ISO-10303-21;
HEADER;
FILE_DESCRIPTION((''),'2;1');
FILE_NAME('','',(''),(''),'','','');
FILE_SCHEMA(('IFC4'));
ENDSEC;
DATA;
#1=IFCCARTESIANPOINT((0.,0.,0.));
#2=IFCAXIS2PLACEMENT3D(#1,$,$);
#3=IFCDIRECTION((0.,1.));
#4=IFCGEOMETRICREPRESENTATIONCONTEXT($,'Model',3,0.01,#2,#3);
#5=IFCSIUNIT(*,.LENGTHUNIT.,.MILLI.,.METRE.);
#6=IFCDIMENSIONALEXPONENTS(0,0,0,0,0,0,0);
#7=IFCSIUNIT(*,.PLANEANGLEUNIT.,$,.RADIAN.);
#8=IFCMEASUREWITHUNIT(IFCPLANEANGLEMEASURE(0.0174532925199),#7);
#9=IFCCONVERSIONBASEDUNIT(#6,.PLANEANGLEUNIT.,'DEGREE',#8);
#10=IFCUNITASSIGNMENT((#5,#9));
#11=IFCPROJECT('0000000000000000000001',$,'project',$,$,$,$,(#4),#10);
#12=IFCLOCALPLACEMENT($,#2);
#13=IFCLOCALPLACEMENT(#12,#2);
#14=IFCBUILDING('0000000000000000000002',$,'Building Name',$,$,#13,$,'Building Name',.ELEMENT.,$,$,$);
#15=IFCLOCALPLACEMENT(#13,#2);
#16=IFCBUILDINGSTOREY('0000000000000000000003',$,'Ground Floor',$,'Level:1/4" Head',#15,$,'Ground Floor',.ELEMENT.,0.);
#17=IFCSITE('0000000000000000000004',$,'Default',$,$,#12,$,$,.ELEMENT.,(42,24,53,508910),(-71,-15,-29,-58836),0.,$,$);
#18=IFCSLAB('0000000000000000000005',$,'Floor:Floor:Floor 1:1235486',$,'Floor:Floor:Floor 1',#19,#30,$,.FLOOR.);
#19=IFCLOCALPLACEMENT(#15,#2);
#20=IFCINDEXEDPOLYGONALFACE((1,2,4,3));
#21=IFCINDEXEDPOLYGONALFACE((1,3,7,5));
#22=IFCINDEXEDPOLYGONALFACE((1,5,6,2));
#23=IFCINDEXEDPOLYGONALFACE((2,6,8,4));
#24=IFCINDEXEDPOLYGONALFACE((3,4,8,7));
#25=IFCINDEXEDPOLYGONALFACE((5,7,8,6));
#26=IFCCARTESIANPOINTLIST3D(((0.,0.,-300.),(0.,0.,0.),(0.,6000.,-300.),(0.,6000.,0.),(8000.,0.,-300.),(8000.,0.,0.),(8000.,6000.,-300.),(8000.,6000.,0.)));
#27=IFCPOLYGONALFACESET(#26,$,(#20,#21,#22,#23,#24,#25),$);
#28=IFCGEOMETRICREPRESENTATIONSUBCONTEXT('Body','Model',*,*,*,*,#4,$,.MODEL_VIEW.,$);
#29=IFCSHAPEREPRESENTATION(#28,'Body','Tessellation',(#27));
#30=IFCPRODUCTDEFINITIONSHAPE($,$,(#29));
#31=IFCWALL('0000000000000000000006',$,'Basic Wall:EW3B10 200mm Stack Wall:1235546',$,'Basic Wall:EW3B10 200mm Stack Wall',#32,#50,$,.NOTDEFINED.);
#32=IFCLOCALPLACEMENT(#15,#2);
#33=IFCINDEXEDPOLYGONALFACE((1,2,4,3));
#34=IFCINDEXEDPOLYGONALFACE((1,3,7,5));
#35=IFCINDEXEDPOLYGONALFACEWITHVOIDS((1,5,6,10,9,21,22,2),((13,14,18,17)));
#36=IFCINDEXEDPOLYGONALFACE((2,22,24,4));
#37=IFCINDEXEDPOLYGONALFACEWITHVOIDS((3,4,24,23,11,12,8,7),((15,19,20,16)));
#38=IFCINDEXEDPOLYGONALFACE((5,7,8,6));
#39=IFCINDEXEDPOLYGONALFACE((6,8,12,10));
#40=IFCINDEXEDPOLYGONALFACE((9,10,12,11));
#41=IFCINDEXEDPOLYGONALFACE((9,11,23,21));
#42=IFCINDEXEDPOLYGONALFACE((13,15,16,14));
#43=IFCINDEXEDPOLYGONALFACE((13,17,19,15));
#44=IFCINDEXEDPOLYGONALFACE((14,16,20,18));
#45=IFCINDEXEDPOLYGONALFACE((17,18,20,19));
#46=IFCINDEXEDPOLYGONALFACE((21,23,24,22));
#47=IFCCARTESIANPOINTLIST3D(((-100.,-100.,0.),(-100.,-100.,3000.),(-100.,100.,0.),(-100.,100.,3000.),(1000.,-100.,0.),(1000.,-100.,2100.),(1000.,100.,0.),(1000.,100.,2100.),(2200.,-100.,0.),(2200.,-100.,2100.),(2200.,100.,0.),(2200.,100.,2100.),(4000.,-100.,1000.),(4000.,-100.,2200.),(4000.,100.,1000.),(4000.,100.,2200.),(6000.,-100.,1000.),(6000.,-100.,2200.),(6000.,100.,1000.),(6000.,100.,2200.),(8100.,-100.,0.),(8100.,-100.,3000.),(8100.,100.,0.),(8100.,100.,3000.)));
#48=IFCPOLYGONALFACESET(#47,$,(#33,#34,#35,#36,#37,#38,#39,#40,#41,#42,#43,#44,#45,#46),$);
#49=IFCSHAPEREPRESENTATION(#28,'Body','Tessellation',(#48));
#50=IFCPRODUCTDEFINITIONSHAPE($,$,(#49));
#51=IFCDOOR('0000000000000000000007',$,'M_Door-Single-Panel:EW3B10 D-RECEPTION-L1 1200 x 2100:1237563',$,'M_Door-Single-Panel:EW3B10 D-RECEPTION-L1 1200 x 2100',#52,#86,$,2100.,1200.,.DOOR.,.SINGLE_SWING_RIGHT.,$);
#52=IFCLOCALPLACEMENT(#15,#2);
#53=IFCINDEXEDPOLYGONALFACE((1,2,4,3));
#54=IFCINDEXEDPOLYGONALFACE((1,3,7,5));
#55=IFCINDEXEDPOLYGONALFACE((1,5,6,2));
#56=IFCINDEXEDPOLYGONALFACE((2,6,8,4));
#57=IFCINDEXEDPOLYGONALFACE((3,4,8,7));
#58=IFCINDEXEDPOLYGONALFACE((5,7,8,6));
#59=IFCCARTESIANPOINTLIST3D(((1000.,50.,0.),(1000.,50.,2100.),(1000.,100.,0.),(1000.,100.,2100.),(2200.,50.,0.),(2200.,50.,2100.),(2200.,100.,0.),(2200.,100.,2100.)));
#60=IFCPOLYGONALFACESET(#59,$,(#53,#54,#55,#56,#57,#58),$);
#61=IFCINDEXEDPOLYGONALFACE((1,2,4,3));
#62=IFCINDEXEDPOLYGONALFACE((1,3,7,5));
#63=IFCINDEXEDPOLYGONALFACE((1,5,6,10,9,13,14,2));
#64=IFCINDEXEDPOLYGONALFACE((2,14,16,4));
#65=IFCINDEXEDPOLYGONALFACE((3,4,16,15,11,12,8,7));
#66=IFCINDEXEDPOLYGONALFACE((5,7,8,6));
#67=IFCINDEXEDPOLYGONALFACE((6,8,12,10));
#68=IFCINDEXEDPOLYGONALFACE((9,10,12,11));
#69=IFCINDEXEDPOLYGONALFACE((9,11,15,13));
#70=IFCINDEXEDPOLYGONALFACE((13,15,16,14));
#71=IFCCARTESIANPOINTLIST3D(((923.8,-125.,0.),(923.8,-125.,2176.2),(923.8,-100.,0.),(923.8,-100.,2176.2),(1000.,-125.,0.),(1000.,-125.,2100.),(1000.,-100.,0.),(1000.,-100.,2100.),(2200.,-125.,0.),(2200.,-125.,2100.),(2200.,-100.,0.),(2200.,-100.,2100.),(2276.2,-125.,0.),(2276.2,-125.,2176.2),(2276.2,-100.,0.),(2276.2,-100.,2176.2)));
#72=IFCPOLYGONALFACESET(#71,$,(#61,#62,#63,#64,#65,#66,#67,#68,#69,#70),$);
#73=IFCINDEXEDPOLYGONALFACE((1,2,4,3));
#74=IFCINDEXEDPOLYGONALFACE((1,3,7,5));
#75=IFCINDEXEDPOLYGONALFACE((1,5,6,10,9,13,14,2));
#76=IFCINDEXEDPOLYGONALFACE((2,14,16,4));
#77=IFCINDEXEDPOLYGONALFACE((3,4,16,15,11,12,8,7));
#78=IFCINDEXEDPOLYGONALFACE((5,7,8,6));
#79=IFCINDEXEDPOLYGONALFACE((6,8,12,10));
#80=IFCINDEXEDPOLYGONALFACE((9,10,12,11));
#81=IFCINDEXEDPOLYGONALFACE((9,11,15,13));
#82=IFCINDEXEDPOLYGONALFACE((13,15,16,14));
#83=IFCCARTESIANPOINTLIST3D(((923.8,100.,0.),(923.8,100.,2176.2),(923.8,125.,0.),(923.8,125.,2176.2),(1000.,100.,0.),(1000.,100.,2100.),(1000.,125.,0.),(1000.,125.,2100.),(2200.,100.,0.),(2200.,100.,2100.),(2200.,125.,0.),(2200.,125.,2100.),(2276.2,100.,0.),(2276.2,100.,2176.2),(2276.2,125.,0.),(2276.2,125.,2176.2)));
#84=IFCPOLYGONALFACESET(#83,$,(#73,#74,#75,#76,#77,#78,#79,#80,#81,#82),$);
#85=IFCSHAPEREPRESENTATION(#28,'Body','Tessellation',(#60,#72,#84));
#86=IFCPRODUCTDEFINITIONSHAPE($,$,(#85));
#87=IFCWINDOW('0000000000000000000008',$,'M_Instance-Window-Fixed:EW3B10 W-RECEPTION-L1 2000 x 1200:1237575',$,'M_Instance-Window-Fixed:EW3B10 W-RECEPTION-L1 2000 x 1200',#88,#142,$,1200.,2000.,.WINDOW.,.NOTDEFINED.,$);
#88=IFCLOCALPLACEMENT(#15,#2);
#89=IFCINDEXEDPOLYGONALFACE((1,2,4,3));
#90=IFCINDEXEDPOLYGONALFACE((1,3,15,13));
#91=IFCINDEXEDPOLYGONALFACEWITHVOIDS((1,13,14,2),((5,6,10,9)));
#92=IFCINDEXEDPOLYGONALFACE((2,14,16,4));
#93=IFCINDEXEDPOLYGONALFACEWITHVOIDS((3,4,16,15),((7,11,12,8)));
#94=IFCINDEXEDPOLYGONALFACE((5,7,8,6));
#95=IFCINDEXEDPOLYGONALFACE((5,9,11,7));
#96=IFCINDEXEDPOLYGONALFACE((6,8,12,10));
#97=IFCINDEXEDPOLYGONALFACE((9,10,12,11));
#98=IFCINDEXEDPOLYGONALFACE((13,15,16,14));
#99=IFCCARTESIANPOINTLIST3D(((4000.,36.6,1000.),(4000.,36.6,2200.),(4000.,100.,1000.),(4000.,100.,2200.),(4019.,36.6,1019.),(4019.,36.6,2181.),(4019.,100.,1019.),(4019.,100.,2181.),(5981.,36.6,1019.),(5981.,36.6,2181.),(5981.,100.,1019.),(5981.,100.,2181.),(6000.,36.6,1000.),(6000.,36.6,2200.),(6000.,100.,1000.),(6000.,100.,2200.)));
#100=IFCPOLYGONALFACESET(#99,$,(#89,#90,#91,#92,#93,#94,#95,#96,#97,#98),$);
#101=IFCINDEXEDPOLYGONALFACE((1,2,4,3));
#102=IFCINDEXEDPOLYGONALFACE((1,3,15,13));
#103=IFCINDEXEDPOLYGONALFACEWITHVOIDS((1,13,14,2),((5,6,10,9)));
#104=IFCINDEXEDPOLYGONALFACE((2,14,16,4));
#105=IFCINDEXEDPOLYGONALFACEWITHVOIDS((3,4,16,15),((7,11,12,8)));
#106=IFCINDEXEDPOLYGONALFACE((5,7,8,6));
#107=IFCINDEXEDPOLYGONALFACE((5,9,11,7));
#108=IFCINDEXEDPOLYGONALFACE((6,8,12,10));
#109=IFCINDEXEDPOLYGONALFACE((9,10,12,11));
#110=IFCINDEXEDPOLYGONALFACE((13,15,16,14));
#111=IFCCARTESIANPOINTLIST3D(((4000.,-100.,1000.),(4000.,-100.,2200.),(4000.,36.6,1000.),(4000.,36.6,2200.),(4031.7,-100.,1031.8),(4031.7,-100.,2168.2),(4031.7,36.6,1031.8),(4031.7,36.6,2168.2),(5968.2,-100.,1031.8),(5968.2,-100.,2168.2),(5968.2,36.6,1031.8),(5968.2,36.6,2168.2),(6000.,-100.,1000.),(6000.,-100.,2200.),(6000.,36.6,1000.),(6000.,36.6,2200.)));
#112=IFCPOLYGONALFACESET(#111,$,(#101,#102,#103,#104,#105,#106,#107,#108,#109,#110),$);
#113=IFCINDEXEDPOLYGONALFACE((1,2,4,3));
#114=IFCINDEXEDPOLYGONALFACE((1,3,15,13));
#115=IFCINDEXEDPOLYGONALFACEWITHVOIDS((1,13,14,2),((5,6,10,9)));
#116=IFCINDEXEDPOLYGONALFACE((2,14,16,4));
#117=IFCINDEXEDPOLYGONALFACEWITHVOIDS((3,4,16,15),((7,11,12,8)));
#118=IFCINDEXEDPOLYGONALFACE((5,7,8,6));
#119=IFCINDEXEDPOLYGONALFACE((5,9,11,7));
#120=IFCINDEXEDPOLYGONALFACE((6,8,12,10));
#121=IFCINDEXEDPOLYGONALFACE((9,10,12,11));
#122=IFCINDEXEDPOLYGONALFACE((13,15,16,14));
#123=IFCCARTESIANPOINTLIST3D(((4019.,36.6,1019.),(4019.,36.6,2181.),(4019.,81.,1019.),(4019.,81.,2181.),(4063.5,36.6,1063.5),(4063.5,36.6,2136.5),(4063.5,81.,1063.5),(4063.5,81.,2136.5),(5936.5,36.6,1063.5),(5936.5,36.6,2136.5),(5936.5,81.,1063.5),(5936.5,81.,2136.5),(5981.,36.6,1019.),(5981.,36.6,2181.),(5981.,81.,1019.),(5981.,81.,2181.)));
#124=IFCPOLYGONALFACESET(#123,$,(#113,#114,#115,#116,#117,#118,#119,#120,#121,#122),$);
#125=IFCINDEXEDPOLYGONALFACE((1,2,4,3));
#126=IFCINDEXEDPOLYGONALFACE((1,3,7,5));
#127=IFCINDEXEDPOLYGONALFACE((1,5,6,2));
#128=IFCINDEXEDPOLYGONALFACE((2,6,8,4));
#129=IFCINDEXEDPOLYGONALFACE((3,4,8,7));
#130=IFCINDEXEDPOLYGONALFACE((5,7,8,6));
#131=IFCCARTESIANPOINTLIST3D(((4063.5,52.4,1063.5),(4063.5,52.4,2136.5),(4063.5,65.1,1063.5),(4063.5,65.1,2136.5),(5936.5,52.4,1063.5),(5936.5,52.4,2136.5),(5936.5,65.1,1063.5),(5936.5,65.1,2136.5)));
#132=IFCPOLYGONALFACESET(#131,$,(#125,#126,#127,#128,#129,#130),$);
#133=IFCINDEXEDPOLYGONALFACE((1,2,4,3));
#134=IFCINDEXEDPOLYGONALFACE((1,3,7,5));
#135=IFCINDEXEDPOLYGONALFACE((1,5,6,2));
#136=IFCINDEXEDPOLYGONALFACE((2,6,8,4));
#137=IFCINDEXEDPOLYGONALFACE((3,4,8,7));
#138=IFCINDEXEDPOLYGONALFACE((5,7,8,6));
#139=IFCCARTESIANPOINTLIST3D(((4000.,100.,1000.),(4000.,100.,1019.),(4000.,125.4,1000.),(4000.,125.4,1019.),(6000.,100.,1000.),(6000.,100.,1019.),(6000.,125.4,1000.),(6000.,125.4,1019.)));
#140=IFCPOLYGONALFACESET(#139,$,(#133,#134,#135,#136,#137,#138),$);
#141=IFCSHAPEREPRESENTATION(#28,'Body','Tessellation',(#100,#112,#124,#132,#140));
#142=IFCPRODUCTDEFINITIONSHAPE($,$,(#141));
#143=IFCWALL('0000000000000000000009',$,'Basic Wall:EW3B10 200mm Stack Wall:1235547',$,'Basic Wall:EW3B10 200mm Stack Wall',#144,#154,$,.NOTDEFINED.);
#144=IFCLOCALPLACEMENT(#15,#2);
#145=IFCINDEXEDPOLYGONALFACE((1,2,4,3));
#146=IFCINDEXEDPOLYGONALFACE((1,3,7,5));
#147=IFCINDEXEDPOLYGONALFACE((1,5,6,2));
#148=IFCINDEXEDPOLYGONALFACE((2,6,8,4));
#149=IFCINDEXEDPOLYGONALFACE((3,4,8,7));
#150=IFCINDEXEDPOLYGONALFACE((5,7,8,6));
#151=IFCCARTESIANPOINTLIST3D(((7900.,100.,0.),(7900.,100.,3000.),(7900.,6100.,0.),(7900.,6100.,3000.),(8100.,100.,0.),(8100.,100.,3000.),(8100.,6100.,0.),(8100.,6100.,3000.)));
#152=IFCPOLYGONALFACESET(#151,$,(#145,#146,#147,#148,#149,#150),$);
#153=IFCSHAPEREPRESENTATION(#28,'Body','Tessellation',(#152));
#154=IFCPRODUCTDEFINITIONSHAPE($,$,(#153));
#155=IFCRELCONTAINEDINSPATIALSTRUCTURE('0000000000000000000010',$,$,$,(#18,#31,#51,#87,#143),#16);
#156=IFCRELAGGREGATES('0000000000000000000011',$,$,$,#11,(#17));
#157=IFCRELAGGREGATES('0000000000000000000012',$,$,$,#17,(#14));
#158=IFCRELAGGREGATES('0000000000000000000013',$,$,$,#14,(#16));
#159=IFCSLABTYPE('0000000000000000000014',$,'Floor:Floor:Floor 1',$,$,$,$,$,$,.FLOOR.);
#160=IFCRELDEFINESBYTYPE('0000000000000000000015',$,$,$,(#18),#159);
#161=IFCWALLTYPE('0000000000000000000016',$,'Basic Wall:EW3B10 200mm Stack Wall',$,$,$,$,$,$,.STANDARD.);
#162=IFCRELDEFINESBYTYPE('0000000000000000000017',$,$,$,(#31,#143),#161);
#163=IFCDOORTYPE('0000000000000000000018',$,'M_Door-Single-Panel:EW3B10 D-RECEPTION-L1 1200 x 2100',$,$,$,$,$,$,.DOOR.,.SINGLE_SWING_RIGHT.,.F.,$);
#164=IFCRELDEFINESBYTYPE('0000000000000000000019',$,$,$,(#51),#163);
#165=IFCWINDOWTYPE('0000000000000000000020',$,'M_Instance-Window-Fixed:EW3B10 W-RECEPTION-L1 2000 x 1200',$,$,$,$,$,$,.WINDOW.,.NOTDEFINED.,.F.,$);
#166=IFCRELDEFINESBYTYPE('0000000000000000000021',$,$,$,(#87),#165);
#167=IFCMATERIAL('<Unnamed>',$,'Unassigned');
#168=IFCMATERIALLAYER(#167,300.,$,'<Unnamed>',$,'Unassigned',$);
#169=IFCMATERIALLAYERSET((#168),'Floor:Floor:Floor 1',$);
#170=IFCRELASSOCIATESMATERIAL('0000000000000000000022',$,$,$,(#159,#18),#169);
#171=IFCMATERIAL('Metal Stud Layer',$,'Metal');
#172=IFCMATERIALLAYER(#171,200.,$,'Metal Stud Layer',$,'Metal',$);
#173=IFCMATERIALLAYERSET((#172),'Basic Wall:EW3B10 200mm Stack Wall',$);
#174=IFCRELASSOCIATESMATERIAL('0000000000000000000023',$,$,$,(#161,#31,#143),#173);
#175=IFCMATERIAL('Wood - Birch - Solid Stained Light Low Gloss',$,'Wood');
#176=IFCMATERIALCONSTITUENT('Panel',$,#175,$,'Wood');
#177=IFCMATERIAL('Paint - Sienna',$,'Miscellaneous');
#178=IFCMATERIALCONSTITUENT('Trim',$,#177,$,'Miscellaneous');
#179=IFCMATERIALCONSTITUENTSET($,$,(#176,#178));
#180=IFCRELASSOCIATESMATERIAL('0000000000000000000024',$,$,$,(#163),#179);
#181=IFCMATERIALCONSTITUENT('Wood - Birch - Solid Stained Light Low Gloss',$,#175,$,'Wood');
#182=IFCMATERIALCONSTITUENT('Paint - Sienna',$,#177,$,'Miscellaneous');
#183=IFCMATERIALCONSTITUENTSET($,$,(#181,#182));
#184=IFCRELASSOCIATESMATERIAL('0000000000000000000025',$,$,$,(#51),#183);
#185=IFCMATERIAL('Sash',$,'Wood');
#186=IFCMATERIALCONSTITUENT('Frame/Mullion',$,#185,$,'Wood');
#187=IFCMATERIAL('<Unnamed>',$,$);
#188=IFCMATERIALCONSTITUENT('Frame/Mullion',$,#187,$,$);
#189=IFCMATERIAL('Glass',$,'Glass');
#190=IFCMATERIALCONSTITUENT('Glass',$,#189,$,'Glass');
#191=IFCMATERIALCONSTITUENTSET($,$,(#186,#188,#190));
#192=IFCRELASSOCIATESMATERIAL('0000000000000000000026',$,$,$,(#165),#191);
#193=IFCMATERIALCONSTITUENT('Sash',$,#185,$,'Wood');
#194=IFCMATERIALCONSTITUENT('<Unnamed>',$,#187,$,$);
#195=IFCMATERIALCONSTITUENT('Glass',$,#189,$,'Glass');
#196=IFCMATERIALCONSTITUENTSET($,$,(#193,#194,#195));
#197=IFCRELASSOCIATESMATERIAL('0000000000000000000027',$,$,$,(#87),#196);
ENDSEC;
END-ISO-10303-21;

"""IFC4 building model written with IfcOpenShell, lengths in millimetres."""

from ifc_helpers import new_model, entity, si_unit, converted_unit, direction, frame, frame_2d, origin, origin_2d_with_axis, place, context, subcontext, project, spatial, polyline, rectangle, outline, extrude, source, transform, mapped, material, layer, layer_set, layer_usage, constituent, constituent_set, type_object, type_shapes, element, fill, save


model = new_model("IFC4")

# Units and contexts
model_context = context("Model", 3, precision=0.01, world=origin(), true_north=direction((0.0, 1.0)))
body_context = subcontext(model_context, "Body", "Model", "MODEL_VIEW")
ifc_project = project(units=[si_unit("LENGTHUNIT", "METRE", prefix="MILLI"), converted_unit("PLANEANGLEUNIT", "DEGREE", entity("IfcPlaneAngleMeasure", 0.0174532925199), si_unit("PLANEANGLEUNIT", "RADIAN"), dimensions=[0, 0, 0, 0, 0, 0, 0])], contexts=[model_context])

# Site, building, storey
site_placement = place(None, origin())
site = spatial("IfcSite", under=ifc_project, at=site_placement, Name="Default", CompositionType="ELEMENT", RefLatitude=(42, 24, 53, 508910), RefLongitude=(-71, -15, -29, -58836), RefElevation=0.0)
building_placement = place(site_placement, origin())
building = spatial("IfcBuilding", under=site, at=building_placement, Name="Building Name", LongName="Building Name", CompositionType="ELEMENT")
storey_placement = place(building_placement, origin())
storey = spatial("IfcBuildingStorey", under=building, at=storey_placement, Name="Ground Floor", ObjectType="Level:1/4\" Head", LongName="Ground Floor", CompositionType="ELEMENT", Elevation=0.0)

# Slab
ifc_material_1 = material(Name="<Unnamed>", Category="Unassigned")
ifc_layer_1 = layer(ifc_material_1, 300.0, Name="<Unnamed>", Category="Unassigned")
ifc_layer_set_1 = layer_set([ifc_layer_1], Name="Floor:Floor:Floor 1")
ifc_layer_usage_1 = layer_usage(ifc_layer_set_1, "AXIS3", "POSITIVE", 0.0)
slab_type = type_object("IfcSlabType", Name="Floor:Floor:Floor 1", PredefinedType="FLOOR", material=ifc_layer_set_1)
slab_placement = place(storey_placement, origin())
element("IfcSlab", 1, at=slab_placement, inside=storey, type_object=slab_type, material=ifc_layer_usage_1, Name="Floor:Floor:Floor 1:1235486", ObjectType="Floor:Floor:Floor 1", PredefinedType="FLOOR", context=body_context, shape_type="SweptSolid", body=[
    extrude(rectangle(XDim=6000.0, YDim=8000.0, at=origin_2d_with_axis()), frame((4000.0, 3000.0, 0.0), z_axis=(0.0, 0.0, -1.0), x_axis=(0.0, 1.0, 0.0)), (0.0, 0.0, 1.0), 300.0),
])

# Wall, openings, door, window
ifc_material_2 = material(Name="Metal Stud Layer", Category="Metal")
ifc_layer_2 = layer(ifc_material_2, 200.0, Name="Metal Stud Layer", Category="Metal")
ifc_layer_set_2 = layer_set([ifc_layer_2], Name="Basic Wall:EW3B10 200mm Stack Wall")
ifc_layer_usage_2 = layer_usage(ifc_layer_set_2, "AXIS2", "NEGATIVE", 100.0)
wall_type = type_object("IfcWallType", Name="Basic Wall:EW3B10 200mm Stack Wall", PredefinedType="STANDARD", material=ifc_layer_set_2)
wall_1_placement = place(storey_placement, frame((-100.0, 0.0, 0.0)))
wall_1 = element("IfcWall", 2, at=wall_1_placement, inside=storey, type_object=wall_type, material=ifc_layer_usage_2, Name="Basic Wall:EW3B10 200mm Stack Wall:1235546", ObjectType="Basic Wall:EW3B10 200mm Stack Wall", PredefinedType="NOTDEFINED", context=body_context, shape_type="SweptSolid", body=[
    extrude(rectangle(XDim=8200.0, YDim=200.0, at=frame_2d((4100.0, 0.0), x_axis=(1.0, 0.0))), origin(), (0.0, 0.0, 1.0), 3000.0),
])
opening_1_placement = place(wall_1_placement, frame((1100.0, -100.0, 0.0)))
opening_1 = element("IfcOpeningElement", 3, at=opening_1_placement, cuts=wall_1, PredefinedType="OPENING", context=body_context, shape_type="SweptSolid", body=[
    extrude(rectangle(XDim=1200.0, YDim=2100.0, at=frame_2d((1050.0, 600.0), x_axis=(0.0, 1.0))), frame((0.0, 0.0, 0.0), z_axis=(0.0, 1.0, 0.0), x_axis=(0.0, 0.0, 1.0)), (0.0, 0.0, 1.0), 200.0),
])
opening_2_placement = place(wall_1_placement, frame((4100.0, -100.0, 1000.0)))
opening_2 = element("IfcOpeningElement", 4, at=opening_2_placement, cuts=wall_1, PredefinedType="OPENING", context=body_context, shape_type="SweptSolid", body=[
    extrude(rectangle(XDim=1200.0, YDim=2000.0, at=frame_2d((600.0, 1000.0), x_axis=(-1.0, 0.0))), frame((0.0, 0.0, 0.0), z_axis=(0.0, 1.0, 0.0), x_axis=(0.0, 0.0, 1.0)), (0.0, 0.0, 1.0), 200.0),
])
ifc_material_3 = material(Name="Wood - Birch - Solid Stained Light Low Gloss", Category="Wood")
ifc_constituent_1 = constituent(ifc_material_3, Name="Wood - Birch - Solid Stained Light Low Gloss", Category="Wood")
ifc_material_4 = material(Name="Paint - Sienna", Category="Miscellaneous")
ifc_constituent_2 = constituent(ifc_material_4, Name="Paint - Sienna", Category="Miscellaneous")
ifc_constituent_set_1 = constituent_set(constituents=[ifc_constituent_1, ifc_constituent_2])
ifc_constituent_3 = constituent(ifc_material_3, Name="Panel", Category="Wood")
ifc_constituent_4 = constituent(ifc_material_4, Name="Trim", Category="Miscellaneous")
ifc_constituent_set_2 = constituent_set(constituents=[ifc_constituent_3, ifc_constituent_4])
door_type = type_object("IfcDoorType", Name="M_Door-Single-Panel:EW3B10 D-RECEPTION-L1 1200 x 2100", OperationType="SINGLE_SWING_RIGHT", ParameterTakesPrecedence=False, PredefinedType="DOOR", material=ifc_constituent_set_2)
shared_shape_1 = source(origin(), body_context, "Body", "SweptSolid", [
    extrude(rectangle(XDim=50.0, YDim=1200.0, at=frame_2d((0.0, 0.0), x_axis=(1.0, 0.0))), frame((600.0, 175.0, 0.0), z_axis=(0.0, 0.0, 1.0), x_axis=(0.0, 1.0, 0.0)), (0.0, 0.0, 1.0), 2100.0),
    extrude(outline(polyline([(-1107.2, -676.2), (1069.0, -676.2), (1069.0, -600.0), (-1031.0, -600.0), (-1031.0, 600.0), (1069.0, 600.0), (1069.0, 676.2), (-1107.2, 676.2), (-1107.2, -676.2)])), frame((600.0, -25.0, 1069.0), z_axis=(0.0, 1.0, 0.0), x_axis=(0.0, 0.0, -1.0)), (0.0, 0.0, 1.0), 25.0),
    extrude(outline(polyline([(-676.2, -1107.2), (676.2, -1107.2), (676.2, 1069.0), (600.0, 1069.0), (600.0, -1031.0), (-600.0, -1031.0), (-600.0, 1069.0), (-676.2, 1069.0), (-676.2, -1107.2)])), frame((600.0, 200.0, 1069.0), z_axis=(0.0, 1.0, 0.0), x_axis=(1.0, 0.0, 0.0)), (0.0, 0.0, 1.0), 25.0),
])
type_shapes(door_type, [shared_shape_1])
door_placement = place(opening_1_placement, origin())
door = element("IfcDoor", 5, at=door_placement, inside=storey, type_object=door_type, material=ifc_constituent_set_1, Name="M_Door-Single-Panel:EW3B10 D-RECEPTION-L1 1200 x 2100:1237563", ObjectType="M_Door-Single-Panel:EW3B10 D-RECEPTION-L1 1200 x 2100", OperationType="SINGLE_SWING_RIGHT", OverallHeight=2100.0, OverallWidth=1200.0, PredefinedType="DOOR", context=body_context, shape_type="MappedRepresentation", body=[
    mapped(shared_shape_1, transform((0.0, 0.0, 0.0), scale=1.0)),
])
fill(opening_1, door)
ifc_material_5 = material(Name="Sash", Category="Wood")
ifc_constituent_5 = constituent(ifc_material_5, Name="Sash", Category="Wood")
ifc_material_6 = material(Name="<Unnamed>")
ifc_constituent_6 = constituent(ifc_material_6, Name="<Unnamed>")
ifc_material_7 = material(Name="Glass", Category="Glass")
ifc_constituent_7 = constituent(ifc_material_7, Name="Glass", Category="Glass")
ifc_constituent_set_3 = constituent_set(constituents=[ifc_constituent_5, ifc_constituent_6, ifc_constituent_7])
ifc_constituent_8 = constituent(ifc_material_5, Name="Frame/Mullion", Category="Wood")
ifc_constituent_9 = constituent(ifc_material_6, Name="Frame/Mullion")
ifc_constituent_10 = constituent(ifc_material_7, Name="Glass", Category="Glass")
ifc_constituent_set_4 = constituent_set(constituents=[ifc_constituent_8, ifc_constituent_9, ifc_constituent_10])
window_type = type_object("IfcWindowType", Name="M_Instance-Window-Fixed:EW3B10 W-RECEPTION-L1 2000 x 1200", ParameterTakesPrecedence=False, PartitioningType="NOTDEFINED", PredefinedType="WINDOW", material=ifc_constituent_set_4)
shared_shape_2 = source(origin(), body_context, "Body", "SweptSolid", [
    extrude(outline(polyline([(-600.0, -1000.0), (600.0, -1000.0), (600.0, 1000.0), (-600.0, 1000.0), (-600.0, -1000.0)]), holes=[polyline([(-581.0, -981.0), (-581.0, 981.0), (581.0, 981.0), (581.0, -981.0), (-581.0, -981.0)])]), frame((1000.0, 136.6, 600.0), z_axis=(0.0, 1.0, 0.0), x_axis=(0.0, 0.0, -1.0)), (0.0, 0.0, 1.0), 63.5),
    extrude(outline(polyline([(-1000.0, -600.0), (1000.0, -600.0), (1000.0, 600.0), (-1000.0, 600.0), (-1000.0, -600.0)]), holes=[polyline([(-968.2, -568.2), (-968.2, 568.2), (968.2, 568.2), (968.2, -568.2), (-968.2, -568.2)])]), frame((1000.0, 0.0, 600.0), z_axis=(0.0, 1.0, 0.0), x_axis=(1.0, 0.0, 0.0)), (0.0, 0.0, 1.0), 136.6),
    extrude(outline(polyline([(-981.0, -581.0), (981.0, -581.0), (981.0, 581.0), (-981.0, 581.0), (-981.0, -581.0)]), holes=[polyline([(-936.5, -536.5), (-936.5, 536.5), (936.5, 536.5), (936.5, -536.5), (-936.5, -536.5)])]), frame((1000.0, 136.6, 600.0), z_axis=(0.0, 1.0, 0.0), x_axis=(1.0, 0.0, 0.0)), (0.0, 0.0, 1.0), 44.5),
    extrude(rectangle(XDim=12.7, YDim=1873.0, at=frame_2d((0.0, 0.0), x_axis=(1.0, 0.0))), frame((1000.0, 158.8, 63.5), z_axis=(0.0, 0.0, 1.0), x_axis=(0.0, 1.0, 0.0)), (0.0, 0.0, 1.0), 1073.0),
    extrude(rectangle(XDim=25.4, YDim=2000.0, at=frame_2d((0.0, 0.0), x_axis=(1.0, 0.0))), frame((1000.0, 212.7, 0.0), z_axis=(0.0, 0.0, 1.0), x_axis=(0.0, -1.0, 0.0)), (0.0, 0.0, 1.0), 19.1),
])
type_shapes(window_type, [shared_shape_2])
window_placement = place(opening_2_placement, origin())
window = element("IfcWindow", 6, at=window_placement, inside=storey, type_object=window_type, material=ifc_constituent_set_3, Name="M_Instance-Window-Fixed:EW3B10 W-RECEPTION-L1 2000 x 1200:1237575", ObjectType="M_Instance-Window-Fixed:EW3B10 W-RECEPTION-L1 2000 x 1200", OverallHeight=1200.0, OverallWidth=2000.0, PartitioningType="NOTDEFINED", PredefinedType="WINDOW", context=body_context, shape_type="MappedRepresentation", body=[
    mapped(shared_shape_2, transform((0.0, 0.0, 0.0), scale=1.0)),
])
fill(opening_2, window)

# Wall
ifc_layer_usage_3 = layer_usage(ifc_layer_set_2, "AXIS2", "NEGATIVE", 100.0)
wall_2_placement = place(storey_placement, frame((8000.0, 100.0, 0.0), z_axis=(0.0, 0.0, 1.0), x_axis=(0.0, 1.0, 0.0)))
element("IfcWall", 7, at=wall_2_placement, inside=storey, type_object=wall_type, material=ifc_layer_usage_3, Name="Basic Wall:EW3B10 200mm Stack Wall:1235547", ObjectType="Basic Wall:EW3B10 200mm Stack Wall", PredefinedType="NOTDEFINED", context=body_context, shape_type="SweptSolid", body=[
    extrude(rectangle(XDim=6000.0, YDim=200.0, at=frame_2d((3000.0, 0.0), x_axis=(-1.0, 0.0))), origin(), (0.0, 0.0, 1.0), 3000.0),
])

save(model, "model.ifc")
